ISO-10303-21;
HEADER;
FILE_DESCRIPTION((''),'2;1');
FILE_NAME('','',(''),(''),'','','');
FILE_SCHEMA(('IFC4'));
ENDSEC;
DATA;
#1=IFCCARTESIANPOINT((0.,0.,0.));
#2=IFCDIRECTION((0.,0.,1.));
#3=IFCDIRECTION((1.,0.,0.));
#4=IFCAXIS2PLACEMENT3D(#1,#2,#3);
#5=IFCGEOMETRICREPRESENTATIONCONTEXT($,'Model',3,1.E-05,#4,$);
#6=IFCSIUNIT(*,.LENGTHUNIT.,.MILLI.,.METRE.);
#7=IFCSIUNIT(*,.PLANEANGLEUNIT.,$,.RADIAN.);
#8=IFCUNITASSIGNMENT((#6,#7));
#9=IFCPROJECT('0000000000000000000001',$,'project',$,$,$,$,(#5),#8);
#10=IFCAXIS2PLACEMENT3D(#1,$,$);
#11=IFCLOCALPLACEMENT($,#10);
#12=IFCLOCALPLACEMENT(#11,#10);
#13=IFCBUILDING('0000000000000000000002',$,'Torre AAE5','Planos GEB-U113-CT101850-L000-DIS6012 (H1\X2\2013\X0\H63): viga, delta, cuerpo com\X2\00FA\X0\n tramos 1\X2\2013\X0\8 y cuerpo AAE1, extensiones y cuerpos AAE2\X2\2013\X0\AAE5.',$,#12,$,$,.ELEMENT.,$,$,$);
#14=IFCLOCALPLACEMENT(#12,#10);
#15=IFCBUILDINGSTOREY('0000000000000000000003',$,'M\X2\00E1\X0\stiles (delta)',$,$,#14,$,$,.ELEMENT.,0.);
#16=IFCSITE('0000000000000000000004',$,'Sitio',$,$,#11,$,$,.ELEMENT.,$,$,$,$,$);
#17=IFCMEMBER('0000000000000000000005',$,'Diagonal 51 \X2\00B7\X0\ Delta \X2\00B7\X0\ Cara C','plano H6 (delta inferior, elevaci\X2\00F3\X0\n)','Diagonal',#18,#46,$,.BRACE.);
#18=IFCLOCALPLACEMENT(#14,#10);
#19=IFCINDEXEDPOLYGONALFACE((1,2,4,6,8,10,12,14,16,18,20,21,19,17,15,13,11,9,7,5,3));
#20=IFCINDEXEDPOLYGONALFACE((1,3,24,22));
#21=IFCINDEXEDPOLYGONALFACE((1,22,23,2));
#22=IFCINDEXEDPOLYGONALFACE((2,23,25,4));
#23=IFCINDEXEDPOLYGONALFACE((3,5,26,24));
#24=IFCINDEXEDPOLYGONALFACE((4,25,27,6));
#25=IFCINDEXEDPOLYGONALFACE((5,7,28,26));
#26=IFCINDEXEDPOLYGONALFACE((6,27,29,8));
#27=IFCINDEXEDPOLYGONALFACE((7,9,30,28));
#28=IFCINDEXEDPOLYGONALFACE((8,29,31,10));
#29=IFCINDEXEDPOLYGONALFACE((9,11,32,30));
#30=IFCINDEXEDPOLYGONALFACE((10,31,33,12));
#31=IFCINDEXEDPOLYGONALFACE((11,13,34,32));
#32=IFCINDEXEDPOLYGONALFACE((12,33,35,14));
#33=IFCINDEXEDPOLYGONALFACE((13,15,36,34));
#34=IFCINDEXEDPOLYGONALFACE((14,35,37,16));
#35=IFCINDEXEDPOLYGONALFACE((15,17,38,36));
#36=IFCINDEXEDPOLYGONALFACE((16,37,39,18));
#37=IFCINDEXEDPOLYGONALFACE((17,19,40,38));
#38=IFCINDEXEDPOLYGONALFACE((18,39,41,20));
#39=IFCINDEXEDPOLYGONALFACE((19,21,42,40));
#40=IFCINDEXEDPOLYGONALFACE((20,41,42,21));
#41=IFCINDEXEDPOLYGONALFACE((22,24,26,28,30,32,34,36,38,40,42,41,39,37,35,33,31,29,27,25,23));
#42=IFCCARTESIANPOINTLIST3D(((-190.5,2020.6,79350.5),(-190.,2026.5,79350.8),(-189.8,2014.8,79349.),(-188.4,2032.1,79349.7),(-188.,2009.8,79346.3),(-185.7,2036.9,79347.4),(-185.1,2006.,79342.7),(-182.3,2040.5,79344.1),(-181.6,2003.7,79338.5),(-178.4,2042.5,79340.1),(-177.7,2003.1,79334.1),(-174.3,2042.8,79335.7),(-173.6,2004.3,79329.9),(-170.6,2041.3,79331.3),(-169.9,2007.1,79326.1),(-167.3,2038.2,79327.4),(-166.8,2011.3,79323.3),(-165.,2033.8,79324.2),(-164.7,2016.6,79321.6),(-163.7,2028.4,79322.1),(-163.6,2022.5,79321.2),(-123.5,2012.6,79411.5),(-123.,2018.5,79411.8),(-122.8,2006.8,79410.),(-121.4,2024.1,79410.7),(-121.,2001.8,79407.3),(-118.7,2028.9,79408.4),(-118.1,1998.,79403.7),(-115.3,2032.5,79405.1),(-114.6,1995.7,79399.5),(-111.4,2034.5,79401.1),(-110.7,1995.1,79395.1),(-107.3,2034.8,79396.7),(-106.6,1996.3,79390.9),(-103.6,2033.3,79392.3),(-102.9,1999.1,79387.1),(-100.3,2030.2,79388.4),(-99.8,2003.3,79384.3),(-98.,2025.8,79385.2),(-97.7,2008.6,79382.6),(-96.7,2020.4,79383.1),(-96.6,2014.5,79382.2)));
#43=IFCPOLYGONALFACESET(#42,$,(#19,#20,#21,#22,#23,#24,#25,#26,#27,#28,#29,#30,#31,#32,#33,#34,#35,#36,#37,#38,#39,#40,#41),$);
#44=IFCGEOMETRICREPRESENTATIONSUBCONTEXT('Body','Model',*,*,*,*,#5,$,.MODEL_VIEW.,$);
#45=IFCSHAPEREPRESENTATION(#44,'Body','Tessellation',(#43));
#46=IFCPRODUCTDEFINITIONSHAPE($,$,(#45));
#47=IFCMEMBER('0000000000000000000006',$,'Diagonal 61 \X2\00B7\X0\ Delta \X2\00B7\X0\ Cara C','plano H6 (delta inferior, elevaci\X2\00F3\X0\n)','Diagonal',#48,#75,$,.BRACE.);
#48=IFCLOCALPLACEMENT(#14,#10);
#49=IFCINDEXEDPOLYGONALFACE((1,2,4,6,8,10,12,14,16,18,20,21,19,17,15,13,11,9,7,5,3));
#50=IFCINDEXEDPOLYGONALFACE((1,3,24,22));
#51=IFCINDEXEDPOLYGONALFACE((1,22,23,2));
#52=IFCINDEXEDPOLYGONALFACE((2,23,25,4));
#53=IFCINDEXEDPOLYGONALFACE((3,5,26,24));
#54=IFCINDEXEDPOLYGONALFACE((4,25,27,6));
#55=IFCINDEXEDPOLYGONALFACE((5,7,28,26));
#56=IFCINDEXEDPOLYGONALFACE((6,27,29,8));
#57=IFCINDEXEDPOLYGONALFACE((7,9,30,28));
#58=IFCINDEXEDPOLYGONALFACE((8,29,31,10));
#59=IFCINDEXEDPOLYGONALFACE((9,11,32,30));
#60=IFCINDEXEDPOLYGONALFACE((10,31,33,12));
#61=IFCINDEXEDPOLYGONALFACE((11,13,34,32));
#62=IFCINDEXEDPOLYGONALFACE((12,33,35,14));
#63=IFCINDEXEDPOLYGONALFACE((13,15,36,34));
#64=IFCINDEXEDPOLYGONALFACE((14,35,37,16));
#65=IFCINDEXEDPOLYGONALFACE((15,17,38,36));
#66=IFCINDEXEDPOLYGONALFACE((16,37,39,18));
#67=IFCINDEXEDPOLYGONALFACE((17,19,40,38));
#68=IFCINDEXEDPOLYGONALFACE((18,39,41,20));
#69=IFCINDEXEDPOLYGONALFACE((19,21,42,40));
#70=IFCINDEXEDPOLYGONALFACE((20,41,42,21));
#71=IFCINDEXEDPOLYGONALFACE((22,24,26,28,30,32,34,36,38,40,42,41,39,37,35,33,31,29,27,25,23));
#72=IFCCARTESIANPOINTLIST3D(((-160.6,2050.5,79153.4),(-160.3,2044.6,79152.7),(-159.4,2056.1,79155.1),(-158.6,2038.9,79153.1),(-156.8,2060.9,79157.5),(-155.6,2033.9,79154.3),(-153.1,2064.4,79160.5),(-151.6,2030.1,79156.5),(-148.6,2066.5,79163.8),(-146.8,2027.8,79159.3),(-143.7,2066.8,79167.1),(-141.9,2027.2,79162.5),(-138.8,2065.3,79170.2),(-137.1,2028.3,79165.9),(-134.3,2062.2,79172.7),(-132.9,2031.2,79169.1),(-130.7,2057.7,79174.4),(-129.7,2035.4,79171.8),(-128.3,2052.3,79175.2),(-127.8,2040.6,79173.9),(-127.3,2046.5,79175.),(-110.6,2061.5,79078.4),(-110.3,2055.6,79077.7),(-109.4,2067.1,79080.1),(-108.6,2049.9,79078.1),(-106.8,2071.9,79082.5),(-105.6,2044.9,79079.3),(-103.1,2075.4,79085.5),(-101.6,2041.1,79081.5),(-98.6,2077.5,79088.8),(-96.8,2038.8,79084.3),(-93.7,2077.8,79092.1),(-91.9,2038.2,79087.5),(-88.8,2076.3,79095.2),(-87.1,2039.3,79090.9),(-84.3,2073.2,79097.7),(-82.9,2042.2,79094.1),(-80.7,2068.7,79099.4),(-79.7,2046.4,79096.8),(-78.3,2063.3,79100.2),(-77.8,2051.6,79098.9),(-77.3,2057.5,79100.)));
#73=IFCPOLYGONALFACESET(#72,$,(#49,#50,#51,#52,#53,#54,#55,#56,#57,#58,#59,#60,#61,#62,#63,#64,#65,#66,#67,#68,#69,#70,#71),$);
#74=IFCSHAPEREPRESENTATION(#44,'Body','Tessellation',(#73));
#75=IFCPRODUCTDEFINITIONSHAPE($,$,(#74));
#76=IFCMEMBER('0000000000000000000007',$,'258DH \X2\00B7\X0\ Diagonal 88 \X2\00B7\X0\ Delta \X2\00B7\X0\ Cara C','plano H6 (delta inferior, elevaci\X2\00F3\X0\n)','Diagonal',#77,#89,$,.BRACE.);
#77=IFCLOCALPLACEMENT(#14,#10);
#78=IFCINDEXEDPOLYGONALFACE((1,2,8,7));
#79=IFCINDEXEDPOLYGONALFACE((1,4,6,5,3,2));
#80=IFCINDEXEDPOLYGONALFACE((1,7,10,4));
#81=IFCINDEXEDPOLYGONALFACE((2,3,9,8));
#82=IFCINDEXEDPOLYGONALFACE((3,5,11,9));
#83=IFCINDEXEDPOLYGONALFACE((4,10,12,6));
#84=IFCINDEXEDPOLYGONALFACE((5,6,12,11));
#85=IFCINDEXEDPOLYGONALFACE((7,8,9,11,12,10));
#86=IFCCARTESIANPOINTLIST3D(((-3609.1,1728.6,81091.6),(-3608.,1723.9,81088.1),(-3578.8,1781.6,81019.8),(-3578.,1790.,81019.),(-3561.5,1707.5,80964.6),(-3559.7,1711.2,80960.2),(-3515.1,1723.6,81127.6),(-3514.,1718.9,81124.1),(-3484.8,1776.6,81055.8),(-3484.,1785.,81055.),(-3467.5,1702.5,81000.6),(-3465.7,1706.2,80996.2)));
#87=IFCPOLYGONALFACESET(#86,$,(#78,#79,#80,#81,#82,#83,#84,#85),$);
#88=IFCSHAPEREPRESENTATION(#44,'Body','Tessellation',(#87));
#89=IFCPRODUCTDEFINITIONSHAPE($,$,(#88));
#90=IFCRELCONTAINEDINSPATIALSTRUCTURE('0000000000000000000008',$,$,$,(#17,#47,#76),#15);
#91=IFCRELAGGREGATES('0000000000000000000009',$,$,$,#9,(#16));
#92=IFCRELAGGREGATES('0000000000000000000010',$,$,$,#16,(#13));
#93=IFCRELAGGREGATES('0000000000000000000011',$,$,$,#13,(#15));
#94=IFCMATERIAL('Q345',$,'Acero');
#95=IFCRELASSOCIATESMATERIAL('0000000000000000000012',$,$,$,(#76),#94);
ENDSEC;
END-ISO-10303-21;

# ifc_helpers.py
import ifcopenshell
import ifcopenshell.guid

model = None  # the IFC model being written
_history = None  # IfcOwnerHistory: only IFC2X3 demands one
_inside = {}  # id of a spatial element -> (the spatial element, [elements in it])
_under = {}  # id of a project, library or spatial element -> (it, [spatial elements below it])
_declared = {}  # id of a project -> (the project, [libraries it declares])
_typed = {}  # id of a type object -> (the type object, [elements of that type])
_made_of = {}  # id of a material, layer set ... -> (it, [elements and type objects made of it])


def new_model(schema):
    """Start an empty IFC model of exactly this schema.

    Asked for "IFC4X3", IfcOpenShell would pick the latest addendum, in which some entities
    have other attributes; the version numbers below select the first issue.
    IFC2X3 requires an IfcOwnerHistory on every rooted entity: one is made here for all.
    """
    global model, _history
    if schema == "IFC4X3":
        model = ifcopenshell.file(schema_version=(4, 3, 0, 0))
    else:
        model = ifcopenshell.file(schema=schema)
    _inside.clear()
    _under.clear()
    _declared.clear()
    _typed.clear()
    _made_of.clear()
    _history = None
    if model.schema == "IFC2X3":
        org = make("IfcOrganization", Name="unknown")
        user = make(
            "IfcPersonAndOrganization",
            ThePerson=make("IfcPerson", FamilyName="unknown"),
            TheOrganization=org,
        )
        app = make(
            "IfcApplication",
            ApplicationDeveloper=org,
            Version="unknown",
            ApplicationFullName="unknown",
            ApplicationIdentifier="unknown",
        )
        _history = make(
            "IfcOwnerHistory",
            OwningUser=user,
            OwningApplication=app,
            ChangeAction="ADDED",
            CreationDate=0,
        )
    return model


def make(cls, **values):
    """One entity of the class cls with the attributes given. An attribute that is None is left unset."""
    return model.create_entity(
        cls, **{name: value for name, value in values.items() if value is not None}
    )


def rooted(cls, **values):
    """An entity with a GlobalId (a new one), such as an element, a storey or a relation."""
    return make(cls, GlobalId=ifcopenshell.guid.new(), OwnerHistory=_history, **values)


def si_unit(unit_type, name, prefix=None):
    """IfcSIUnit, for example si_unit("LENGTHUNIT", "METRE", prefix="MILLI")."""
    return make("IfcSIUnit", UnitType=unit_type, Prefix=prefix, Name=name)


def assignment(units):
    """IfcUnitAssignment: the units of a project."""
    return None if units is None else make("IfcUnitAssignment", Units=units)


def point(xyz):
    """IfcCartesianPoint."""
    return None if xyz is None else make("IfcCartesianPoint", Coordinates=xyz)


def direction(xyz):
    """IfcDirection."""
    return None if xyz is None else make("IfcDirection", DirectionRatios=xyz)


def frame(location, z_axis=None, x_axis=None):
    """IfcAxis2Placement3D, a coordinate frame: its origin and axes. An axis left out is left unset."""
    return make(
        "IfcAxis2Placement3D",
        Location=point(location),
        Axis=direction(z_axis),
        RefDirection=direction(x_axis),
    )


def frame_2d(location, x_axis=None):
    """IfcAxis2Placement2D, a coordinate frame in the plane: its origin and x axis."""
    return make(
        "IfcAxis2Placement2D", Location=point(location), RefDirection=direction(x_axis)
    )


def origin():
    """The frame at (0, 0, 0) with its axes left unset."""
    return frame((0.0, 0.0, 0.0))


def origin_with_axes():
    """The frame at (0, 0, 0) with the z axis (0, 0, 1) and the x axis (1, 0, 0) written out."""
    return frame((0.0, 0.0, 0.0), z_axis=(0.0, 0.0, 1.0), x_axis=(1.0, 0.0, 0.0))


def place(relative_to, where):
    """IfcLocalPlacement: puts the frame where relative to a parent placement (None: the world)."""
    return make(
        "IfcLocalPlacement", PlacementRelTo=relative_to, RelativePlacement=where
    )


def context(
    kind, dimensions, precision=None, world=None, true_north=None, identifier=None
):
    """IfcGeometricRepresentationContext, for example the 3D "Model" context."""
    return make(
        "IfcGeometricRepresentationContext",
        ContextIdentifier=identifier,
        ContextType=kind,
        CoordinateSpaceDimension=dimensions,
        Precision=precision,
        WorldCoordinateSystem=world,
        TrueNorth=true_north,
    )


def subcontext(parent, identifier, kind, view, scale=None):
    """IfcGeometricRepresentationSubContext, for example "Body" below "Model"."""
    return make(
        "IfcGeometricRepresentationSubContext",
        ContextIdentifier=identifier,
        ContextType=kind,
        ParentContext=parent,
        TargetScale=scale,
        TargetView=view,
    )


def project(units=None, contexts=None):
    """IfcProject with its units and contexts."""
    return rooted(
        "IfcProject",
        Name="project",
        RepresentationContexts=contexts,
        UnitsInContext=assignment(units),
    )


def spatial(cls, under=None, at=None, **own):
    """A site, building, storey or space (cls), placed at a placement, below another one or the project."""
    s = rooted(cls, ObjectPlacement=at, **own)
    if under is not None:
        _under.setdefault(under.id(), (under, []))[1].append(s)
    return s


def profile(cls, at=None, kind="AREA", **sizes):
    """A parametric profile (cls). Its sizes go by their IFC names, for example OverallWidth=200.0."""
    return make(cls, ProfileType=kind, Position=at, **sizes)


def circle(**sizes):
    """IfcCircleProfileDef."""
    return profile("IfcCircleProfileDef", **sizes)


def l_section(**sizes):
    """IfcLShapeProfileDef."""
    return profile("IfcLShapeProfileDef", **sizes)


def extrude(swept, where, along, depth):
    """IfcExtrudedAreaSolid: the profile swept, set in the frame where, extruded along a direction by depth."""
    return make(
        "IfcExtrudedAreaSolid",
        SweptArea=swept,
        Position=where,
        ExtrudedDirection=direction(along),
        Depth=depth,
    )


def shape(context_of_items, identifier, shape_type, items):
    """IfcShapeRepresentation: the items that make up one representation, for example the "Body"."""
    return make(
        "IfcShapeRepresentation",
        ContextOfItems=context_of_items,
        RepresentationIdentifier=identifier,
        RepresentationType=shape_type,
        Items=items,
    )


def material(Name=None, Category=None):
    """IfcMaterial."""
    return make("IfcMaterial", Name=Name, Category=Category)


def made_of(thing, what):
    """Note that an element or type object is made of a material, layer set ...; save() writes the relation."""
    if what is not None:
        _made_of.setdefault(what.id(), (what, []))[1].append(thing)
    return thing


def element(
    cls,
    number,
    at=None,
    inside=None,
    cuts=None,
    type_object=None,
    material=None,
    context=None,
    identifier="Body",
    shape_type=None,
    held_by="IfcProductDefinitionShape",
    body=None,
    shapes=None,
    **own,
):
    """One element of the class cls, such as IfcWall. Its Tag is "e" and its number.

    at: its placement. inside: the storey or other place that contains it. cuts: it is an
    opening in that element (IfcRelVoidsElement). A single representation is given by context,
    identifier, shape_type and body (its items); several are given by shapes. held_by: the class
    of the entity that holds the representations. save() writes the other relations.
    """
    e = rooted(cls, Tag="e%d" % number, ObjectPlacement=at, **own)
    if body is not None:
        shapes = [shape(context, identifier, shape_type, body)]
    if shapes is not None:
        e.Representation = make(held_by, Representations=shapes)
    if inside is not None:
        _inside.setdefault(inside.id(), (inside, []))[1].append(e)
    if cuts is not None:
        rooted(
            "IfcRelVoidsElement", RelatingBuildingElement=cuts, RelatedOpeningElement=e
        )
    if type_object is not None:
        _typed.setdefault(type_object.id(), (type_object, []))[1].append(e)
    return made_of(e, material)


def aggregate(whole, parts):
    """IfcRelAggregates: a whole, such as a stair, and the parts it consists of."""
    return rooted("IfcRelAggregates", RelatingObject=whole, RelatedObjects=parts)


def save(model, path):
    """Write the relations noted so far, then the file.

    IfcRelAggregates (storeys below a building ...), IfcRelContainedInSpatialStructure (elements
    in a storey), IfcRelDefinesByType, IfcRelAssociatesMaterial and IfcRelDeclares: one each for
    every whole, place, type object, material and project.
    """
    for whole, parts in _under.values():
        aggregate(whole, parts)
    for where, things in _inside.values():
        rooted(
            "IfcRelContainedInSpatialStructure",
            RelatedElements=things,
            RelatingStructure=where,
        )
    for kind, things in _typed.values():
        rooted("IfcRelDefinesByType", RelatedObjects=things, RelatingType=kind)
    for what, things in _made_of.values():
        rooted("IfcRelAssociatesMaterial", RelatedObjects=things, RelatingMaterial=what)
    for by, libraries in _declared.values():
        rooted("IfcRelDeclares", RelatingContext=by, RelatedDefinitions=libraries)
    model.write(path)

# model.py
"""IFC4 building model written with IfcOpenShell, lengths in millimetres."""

from ifc_helpers import new_model, si_unit, frame, frame_2d, origin, origin_with_axes, place, context, subcontext, project, spatial, circle, l_section, extrude, material, element, save


model = new_model("IFC4")

# Units and contexts
model_context = context("Model", 3, precision=1e-05, world=origin_with_axes())
body_context = subcontext(model_context, "Body", "Model", "MODEL_VIEW")
ifc_project = project(units=[si_unit("LENGTHUNIT", "METRE", prefix="MILLI"), si_unit("PLANEANGLEUNIT", "RADIAN")], contexts=[model_context])

# Site, building, storey
site_placement = place(None, origin())
site = spatial("IfcSite", under=ifc_project, at=site_placement, Name="Sitio", CompositionType="ELEMENT")
building_placement = place(site_placement, origin())
building = spatial("IfcBuilding", under=site, at=building_placement, Name="Torre AAE5", Description="Planos GEB-U113-CT101850-L000-DIS6012 (H1–H63): viga, delta, cuerpo común tramos 1–8 y cuerpo AAE1, extensiones y cuerpos AAE2–AAE5.", CompositionType="ELEMENT")
storey_placement = place(building_placement, origin())
storey = spatial("IfcBuildingStorey", under=building, at=storey_placement, Name="Mástiles (delta)", CompositionType="ELEMENT", Elevation=0.0)

# Members
ifc_material_1 = material(Name="Q345", Category="Acero")
member_1_placement = place(storey_placement, frame((-177.0, 2023.0, 79336.0), z_axis=(0.736575, -0.087949, 0.670613), x_axis=(-0.032506, -0.994967, -0.094784)))
element("IfcMember", 1, at=member_1_placement, inside=storey, Name="Diagonal 51 · Delta · Cara C", Description="plano H6 (delta inferior, elevación)", ObjectType="Diagonal", PredefinedType="BRACE", context=body_context, shape_type="SweptSolid", body=[
    extrude(circle(Radius=20.0), None, (0.0, 0.0, 1.0), 91.0),
])
member_2_placement = place(storey_placement, frame((-144.0, 2047.0, 79164.0), z_axis=(0.550615, 0.121135, -0.825923), x_axis=(0.107346, -0.991475, -0.073852)))
element("IfcMember", 2, at=member_2_placement, inside=storey, Name="Diagonal 61 · Delta · Cara C", Description="plano H6 (delta inferior, elevación)", ObjectType="Diagonal", PredefinedType="BRACE", context=body_context, shape_type="SweptSolid", body=[
    extrude(circle(Radius=20.0), None, (0.0, 0.0, 1.0), 90.8),
])
member_3_placement = place(storey_placement, frame((-3484.0, 1785.0, 81055.0), z_axis=(-0.932707, 0.049612, -0.357207), x_axis=(0.183185, -0.788021, -0.587764)))
element("IfcMember", 3, at=member_3_placement, inside=storey, material=ifc_material_1, Name="258DH · Diagonal 88 · Delta · Cara C", Description="plano H6 (delta inferior, elevación)", ObjectType="Diagonal", PredefinedType="BRACE", context=body_context, shape_type="SweptSolid", body=[
    extrude(l_section(Depth=100.0, Width=100.0, Thickness=6.0, at=frame_2d((50.0, 50.0))), None, (0.0, 0.0, 1.0), 100.8),
])

save(model, "model.ifc")
